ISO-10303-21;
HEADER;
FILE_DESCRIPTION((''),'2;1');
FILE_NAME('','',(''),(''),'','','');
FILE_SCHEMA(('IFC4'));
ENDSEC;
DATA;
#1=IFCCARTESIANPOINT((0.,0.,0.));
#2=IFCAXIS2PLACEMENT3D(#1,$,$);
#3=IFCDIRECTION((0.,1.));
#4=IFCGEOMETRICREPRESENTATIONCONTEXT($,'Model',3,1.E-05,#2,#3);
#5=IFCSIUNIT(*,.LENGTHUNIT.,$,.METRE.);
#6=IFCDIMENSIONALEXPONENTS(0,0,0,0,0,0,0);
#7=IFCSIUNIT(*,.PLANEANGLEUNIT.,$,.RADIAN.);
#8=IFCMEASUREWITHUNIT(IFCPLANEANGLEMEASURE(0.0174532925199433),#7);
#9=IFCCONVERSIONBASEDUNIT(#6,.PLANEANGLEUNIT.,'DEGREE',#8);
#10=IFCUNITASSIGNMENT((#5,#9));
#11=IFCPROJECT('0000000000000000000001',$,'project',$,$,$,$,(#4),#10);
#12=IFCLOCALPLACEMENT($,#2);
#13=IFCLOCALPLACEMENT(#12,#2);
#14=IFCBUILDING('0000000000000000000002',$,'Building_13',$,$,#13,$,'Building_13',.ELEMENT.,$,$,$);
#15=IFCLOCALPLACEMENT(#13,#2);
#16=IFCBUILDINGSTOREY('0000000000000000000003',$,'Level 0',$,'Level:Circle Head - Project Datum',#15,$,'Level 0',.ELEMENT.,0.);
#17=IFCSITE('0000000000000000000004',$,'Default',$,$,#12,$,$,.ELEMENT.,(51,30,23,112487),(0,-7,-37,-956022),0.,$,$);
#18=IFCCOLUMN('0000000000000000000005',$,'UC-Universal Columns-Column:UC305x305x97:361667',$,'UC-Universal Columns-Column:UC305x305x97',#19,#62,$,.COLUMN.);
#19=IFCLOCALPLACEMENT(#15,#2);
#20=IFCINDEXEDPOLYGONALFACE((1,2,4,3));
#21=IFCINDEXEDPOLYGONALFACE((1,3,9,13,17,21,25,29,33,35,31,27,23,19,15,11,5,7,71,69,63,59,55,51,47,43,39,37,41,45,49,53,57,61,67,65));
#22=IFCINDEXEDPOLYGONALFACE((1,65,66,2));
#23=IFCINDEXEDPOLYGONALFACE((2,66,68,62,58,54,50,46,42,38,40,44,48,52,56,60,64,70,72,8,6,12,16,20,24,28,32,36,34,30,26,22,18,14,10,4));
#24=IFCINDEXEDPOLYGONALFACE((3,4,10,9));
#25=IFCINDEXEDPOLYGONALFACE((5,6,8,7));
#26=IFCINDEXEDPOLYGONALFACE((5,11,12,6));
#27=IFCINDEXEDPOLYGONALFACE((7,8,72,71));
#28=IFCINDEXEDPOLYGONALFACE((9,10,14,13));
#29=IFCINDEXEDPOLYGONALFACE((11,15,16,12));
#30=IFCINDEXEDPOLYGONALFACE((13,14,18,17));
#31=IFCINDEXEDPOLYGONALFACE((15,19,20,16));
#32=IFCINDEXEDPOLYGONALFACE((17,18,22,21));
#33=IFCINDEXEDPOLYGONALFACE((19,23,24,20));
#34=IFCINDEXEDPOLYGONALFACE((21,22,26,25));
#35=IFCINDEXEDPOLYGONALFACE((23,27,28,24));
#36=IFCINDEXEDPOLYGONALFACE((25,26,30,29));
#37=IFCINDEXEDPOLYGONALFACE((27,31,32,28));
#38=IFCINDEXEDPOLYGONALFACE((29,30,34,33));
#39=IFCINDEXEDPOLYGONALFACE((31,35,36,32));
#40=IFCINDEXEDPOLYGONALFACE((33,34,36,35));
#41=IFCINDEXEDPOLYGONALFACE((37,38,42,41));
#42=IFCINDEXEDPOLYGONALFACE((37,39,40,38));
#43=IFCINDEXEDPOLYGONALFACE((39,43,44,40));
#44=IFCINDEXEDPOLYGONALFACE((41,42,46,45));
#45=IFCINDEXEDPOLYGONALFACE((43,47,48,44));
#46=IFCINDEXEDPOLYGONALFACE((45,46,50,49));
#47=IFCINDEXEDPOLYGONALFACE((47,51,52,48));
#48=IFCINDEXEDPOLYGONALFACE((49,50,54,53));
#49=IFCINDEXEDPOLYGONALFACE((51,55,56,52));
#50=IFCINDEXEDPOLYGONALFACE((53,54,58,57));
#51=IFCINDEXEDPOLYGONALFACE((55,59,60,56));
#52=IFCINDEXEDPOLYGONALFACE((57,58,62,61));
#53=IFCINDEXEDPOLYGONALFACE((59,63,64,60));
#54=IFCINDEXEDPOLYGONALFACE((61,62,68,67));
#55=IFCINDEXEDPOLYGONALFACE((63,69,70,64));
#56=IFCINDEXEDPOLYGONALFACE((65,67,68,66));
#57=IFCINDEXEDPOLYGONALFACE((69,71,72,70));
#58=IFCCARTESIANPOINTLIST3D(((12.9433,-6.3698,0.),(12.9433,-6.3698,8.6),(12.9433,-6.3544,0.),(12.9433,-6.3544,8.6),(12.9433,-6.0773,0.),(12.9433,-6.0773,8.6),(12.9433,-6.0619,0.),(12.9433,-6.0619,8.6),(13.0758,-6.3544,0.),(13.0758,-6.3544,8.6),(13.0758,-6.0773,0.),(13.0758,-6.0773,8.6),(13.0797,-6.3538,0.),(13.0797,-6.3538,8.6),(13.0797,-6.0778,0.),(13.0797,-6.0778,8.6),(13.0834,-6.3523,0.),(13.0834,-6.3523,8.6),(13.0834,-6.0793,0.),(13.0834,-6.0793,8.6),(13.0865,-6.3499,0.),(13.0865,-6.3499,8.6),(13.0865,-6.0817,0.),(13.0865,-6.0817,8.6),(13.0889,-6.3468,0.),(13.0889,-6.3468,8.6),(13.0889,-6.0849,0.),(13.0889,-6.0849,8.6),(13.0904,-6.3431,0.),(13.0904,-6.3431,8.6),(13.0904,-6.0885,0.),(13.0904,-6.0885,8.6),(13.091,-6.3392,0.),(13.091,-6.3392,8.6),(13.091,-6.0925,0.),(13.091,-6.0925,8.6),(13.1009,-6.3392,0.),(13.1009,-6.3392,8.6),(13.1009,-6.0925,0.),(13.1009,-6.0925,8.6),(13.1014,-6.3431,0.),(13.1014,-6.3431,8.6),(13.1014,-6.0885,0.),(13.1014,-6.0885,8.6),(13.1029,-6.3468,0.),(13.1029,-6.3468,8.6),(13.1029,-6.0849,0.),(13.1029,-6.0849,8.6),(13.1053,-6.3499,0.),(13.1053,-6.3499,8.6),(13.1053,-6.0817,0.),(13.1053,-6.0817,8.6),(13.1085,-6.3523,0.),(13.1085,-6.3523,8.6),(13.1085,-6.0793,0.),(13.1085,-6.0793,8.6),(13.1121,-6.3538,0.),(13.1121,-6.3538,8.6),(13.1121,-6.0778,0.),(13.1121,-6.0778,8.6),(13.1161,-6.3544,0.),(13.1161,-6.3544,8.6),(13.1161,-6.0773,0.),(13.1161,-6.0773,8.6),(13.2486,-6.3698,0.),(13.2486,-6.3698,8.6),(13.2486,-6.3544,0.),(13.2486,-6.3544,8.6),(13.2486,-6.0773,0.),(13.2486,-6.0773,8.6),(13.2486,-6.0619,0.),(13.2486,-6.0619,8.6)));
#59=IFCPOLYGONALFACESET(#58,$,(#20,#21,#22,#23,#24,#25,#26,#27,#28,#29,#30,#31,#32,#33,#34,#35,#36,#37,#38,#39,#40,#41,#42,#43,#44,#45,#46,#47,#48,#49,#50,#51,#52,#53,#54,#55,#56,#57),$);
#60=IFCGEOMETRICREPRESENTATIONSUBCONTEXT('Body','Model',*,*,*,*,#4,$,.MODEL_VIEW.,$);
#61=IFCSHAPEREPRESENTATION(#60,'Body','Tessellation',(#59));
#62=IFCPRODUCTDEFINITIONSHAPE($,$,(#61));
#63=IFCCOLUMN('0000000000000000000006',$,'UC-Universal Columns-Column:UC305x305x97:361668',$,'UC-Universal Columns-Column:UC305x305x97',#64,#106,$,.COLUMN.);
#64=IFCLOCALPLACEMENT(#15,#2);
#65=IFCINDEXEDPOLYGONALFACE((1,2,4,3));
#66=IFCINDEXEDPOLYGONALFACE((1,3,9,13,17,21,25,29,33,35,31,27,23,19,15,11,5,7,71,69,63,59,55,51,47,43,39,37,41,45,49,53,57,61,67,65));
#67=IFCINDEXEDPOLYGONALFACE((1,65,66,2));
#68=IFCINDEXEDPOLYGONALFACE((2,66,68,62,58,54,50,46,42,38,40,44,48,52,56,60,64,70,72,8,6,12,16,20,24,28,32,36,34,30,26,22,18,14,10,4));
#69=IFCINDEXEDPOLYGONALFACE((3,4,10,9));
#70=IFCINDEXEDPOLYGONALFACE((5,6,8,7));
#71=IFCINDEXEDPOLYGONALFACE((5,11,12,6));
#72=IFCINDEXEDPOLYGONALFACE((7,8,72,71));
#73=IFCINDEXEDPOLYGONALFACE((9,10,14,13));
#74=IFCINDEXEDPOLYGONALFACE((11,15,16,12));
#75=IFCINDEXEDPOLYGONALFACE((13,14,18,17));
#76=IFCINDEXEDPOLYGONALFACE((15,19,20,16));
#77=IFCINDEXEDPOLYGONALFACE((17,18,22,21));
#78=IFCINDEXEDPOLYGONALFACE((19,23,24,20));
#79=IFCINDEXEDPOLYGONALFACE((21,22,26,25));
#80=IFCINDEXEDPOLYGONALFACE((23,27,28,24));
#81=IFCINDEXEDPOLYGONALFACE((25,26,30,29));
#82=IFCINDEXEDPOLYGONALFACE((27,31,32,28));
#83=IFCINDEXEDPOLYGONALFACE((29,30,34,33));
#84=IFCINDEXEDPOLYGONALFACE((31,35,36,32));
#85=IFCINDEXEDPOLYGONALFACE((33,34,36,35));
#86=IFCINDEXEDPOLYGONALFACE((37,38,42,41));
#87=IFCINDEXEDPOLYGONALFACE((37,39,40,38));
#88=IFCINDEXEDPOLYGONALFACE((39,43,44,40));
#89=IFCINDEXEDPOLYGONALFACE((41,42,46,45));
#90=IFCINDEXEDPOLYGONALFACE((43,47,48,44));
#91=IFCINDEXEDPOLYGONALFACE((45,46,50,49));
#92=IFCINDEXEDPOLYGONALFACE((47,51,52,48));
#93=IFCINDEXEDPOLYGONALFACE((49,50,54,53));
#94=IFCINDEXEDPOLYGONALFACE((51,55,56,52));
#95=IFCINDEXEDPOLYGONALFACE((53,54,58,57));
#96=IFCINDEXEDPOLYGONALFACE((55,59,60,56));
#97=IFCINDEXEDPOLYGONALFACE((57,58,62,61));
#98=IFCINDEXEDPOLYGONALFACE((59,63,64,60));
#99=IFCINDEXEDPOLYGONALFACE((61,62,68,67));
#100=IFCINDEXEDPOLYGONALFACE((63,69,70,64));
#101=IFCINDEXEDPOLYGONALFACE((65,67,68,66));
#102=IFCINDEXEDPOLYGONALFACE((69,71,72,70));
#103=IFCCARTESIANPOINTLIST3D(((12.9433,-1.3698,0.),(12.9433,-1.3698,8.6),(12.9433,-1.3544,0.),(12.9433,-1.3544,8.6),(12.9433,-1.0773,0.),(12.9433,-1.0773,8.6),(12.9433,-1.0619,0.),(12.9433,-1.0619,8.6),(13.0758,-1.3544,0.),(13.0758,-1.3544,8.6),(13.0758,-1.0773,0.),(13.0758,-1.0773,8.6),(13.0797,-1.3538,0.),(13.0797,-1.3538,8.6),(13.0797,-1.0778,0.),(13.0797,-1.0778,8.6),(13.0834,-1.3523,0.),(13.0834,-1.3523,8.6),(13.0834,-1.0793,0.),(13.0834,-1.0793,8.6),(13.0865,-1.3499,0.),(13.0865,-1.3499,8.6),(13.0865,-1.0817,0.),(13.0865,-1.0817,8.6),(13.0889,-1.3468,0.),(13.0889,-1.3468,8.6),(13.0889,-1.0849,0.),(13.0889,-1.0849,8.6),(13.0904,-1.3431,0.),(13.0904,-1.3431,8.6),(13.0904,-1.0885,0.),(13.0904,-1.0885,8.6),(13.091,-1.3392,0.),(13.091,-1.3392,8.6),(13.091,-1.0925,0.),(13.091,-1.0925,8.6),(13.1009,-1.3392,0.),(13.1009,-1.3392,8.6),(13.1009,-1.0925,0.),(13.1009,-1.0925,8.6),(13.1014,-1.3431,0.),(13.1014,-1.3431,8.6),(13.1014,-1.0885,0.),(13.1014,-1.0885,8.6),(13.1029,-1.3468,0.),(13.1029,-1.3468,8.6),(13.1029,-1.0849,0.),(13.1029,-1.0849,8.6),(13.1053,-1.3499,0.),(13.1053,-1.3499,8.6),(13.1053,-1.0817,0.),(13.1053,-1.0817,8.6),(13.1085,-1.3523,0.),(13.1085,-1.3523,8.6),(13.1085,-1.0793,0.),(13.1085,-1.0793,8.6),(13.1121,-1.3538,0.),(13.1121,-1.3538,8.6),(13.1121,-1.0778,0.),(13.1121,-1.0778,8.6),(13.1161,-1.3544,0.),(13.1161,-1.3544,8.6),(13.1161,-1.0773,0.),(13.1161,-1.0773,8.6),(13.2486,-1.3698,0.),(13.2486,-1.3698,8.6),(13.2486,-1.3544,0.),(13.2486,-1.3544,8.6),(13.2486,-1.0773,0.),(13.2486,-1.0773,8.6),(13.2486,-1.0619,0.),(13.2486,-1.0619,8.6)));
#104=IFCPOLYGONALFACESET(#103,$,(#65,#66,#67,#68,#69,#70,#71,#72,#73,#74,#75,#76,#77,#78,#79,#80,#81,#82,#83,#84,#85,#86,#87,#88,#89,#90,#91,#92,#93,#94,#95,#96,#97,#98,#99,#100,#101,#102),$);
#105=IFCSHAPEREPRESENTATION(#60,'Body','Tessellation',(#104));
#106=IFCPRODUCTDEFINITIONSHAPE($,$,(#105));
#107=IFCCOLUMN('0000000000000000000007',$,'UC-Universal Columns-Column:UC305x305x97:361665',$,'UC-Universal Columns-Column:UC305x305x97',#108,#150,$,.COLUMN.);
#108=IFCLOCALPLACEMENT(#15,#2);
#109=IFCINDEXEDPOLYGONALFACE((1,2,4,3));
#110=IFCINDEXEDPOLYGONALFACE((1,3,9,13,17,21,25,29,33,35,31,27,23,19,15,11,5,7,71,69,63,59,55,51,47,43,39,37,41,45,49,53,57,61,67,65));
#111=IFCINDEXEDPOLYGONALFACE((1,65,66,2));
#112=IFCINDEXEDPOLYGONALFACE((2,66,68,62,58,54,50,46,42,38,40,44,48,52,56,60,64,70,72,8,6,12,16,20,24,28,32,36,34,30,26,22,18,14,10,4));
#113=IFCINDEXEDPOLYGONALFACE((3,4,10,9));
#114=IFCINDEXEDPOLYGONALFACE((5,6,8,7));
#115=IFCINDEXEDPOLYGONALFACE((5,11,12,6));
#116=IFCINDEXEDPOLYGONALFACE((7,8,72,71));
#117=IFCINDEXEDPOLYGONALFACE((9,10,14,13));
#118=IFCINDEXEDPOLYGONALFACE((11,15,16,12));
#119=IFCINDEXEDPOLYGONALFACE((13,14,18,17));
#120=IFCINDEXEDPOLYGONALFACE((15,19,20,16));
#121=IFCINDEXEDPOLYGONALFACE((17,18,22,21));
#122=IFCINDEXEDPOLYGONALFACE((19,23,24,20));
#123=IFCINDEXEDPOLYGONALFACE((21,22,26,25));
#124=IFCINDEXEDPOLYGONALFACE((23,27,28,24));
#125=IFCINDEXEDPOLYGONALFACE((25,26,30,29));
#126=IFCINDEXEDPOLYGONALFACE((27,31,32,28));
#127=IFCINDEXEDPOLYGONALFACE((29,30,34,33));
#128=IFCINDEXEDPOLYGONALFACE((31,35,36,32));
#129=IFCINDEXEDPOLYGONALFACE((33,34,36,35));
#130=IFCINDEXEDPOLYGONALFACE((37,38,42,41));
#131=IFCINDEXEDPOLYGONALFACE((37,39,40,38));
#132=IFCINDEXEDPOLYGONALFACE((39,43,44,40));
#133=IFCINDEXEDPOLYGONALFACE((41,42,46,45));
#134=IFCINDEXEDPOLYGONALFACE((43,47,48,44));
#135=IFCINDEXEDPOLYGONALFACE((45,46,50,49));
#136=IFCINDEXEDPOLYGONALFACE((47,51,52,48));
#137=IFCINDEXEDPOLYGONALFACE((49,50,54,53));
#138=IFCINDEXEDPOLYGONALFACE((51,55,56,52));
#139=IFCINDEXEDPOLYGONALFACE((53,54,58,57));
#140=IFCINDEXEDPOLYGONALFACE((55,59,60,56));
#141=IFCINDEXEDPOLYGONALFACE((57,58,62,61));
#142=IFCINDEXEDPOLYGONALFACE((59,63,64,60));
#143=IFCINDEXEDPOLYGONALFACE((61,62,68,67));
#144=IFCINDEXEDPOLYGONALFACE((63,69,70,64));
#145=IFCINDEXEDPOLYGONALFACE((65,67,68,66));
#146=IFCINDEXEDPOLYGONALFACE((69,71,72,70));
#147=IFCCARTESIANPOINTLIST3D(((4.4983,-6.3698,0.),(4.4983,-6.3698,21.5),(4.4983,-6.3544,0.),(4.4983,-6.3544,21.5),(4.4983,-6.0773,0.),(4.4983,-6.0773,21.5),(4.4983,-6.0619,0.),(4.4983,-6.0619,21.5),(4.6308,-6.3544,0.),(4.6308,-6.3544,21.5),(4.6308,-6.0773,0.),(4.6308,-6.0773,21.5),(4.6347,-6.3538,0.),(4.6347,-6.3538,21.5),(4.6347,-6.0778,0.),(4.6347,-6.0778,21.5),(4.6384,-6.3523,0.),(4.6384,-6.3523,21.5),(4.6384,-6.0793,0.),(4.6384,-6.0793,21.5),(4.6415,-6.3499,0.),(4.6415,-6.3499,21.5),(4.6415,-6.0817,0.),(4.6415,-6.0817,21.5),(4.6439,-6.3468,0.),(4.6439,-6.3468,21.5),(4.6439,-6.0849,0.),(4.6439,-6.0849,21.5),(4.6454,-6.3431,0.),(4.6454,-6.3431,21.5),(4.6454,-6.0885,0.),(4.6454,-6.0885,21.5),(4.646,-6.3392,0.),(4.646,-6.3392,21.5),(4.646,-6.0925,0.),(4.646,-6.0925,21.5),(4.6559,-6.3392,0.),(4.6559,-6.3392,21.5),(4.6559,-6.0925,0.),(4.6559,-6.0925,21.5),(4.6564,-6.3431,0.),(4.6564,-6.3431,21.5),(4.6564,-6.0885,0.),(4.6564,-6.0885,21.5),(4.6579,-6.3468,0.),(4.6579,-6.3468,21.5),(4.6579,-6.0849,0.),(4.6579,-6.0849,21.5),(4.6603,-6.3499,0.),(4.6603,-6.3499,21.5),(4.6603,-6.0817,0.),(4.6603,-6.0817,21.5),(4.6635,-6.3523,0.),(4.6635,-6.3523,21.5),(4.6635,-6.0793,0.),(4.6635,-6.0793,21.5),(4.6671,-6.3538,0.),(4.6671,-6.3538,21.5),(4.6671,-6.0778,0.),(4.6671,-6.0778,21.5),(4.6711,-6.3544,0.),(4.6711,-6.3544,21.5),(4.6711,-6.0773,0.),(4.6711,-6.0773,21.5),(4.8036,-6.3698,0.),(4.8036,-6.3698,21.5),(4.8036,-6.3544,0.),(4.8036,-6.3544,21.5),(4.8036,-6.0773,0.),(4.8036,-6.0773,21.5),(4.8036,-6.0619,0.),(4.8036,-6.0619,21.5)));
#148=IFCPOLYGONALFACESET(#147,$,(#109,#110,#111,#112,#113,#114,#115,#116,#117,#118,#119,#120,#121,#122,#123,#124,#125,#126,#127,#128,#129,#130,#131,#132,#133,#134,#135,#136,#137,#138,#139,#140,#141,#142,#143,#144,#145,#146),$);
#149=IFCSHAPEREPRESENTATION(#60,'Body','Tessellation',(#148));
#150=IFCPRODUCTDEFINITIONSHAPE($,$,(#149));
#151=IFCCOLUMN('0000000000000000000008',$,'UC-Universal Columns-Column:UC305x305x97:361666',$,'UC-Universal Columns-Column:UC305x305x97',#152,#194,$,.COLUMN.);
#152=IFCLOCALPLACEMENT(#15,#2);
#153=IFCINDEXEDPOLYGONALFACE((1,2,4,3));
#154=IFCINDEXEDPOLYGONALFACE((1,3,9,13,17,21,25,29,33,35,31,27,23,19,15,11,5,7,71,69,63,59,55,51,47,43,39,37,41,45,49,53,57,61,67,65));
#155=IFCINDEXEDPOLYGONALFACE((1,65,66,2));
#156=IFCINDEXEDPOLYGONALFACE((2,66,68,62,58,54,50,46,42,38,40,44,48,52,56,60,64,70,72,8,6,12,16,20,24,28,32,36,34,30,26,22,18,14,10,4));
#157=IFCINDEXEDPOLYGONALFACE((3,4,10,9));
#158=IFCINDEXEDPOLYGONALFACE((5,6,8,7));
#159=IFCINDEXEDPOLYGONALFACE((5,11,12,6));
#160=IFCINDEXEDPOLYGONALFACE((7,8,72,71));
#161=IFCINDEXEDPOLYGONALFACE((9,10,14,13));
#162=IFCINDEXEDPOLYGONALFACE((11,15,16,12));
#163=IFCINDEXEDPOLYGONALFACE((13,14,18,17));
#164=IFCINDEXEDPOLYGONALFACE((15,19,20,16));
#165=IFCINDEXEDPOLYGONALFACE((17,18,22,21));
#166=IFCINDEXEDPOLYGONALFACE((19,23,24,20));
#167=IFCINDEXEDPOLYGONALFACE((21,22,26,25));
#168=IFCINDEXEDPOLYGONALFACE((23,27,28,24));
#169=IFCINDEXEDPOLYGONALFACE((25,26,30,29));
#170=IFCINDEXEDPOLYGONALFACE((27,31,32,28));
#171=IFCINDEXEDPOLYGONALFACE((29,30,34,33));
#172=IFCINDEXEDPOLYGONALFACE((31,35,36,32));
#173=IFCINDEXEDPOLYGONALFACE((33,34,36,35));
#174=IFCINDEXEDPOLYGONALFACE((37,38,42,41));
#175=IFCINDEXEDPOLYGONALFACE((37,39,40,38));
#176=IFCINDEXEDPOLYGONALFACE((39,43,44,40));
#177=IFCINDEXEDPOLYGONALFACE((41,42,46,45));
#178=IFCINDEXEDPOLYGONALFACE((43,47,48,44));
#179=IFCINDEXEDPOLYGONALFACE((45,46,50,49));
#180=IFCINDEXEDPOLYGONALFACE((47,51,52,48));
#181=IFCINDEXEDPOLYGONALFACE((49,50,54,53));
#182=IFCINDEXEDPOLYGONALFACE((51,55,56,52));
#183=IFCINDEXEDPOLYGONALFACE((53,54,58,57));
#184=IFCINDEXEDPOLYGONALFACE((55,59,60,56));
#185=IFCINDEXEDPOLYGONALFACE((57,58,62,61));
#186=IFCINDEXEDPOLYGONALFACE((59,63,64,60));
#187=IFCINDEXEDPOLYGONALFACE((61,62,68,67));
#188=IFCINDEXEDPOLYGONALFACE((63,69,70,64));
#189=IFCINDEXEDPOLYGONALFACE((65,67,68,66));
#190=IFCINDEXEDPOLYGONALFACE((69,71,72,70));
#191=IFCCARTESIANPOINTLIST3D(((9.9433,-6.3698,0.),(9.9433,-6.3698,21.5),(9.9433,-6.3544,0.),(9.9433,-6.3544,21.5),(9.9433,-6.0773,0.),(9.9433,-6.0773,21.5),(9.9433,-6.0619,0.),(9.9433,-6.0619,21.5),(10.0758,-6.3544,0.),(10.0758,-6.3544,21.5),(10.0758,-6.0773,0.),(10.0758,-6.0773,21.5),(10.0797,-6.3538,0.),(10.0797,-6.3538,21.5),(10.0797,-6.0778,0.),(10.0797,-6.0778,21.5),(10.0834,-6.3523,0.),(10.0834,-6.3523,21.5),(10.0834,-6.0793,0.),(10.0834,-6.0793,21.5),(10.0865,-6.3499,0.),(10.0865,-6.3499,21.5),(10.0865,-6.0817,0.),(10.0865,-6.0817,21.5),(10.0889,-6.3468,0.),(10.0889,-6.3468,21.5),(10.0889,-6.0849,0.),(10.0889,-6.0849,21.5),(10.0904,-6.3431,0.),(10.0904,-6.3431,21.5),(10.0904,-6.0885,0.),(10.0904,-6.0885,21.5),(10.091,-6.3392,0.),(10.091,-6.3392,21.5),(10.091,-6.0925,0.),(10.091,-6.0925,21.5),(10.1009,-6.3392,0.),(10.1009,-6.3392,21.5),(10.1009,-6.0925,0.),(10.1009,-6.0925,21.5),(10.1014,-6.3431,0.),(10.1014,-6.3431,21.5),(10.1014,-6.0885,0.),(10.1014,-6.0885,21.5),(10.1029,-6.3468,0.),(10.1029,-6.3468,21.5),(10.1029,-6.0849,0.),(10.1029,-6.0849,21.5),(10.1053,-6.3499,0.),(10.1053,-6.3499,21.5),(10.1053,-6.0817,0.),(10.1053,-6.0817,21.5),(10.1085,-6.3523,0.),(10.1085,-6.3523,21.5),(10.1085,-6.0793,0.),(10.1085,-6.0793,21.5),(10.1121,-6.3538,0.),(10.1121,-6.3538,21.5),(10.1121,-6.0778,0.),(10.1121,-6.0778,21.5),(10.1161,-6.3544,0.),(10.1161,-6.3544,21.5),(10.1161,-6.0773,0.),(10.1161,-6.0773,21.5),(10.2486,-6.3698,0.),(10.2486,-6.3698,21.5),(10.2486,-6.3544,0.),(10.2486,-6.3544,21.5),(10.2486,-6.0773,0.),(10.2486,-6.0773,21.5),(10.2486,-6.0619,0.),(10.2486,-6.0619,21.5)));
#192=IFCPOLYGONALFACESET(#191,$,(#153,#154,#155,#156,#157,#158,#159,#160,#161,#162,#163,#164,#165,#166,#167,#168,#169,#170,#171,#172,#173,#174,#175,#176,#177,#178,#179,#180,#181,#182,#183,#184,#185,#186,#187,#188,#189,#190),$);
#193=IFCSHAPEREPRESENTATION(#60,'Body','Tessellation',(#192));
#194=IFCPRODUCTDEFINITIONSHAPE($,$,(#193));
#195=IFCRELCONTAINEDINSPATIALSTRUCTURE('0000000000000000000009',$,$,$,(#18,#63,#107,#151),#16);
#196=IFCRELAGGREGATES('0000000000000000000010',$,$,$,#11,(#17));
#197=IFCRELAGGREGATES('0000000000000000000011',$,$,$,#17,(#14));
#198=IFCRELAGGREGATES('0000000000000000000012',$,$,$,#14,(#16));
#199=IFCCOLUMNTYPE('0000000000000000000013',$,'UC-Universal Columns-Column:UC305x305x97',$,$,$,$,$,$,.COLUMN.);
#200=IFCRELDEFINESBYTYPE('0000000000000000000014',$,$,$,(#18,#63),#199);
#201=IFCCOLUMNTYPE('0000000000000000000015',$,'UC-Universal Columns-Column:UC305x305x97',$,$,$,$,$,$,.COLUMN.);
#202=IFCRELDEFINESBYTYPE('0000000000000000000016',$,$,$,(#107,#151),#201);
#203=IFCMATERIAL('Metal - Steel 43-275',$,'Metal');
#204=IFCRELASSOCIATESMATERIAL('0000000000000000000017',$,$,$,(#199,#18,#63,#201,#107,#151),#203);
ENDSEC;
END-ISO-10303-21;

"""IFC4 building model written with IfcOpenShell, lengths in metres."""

from ifc_helpers import new_model, entity, si_unit, converted_unit, direction, frame, origin, place, context, subcontext, project, spatial, line, arc, indexed_curve, outline, extrude, source, transform, mapped, material, type_object, type_shapes, element, save


model = new_model("IFC4")

# Units and contexts
model_context = context("Model", 3, precision=1e-05, world=origin(), true_north=direction((0.0, 1.0)))
body_context = subcontext(model_context, "Body", "Model", "MODEL_VIEW")
ifc_project = project(units=[si_unit("LENGTHUNIT", "METRE"), converted_unit("PLANEANGLEUNIT", "DEGREE", entity("IfcPlaneAngleMeasure", 0.0174532925199433), si_unit("PLANEANGLEUNIT", "RADIAN"), dimensions=[0, 0, 0, 0, 0, 0, 0])], contexts=[model_context])

# Site, building, storey
site_placement = place(None, origin())
site = spatial("IfcSite", under=ifc_project, at=site_placement, Name="Default", CompositionType="ELEMENT", RefLatitude=(51, 30, 23, 112487), RefLongitude=(0, -7, -37, -956022), RefElevation=0.0)
building_placement = place(site_placement, origin())
building = spatial("IfcBuilding", under=site, at=building_placement, Name="Building_13", LongName="Building_13", CompositionType="ELEMENT")
storey_placement = place(building_placement, origin())
storey = spatial("IfcBuildingStorey", under=building, at=storey_placement, Name="Level 0", ObjectType="Level:Circle Head - Project Datum", LongName="Level 0", CompositionType="ELEMENT", Elevation=0.0)

# Columns
ifc_material_1 = material(Name="Metal - Steel 43-275", Category="Metal")
column_type_1 = type_object("IfcColumnType", Name="UC-Universal Columns-Column:UC305x305x97", PredefinedType="COLUMN", material=ifc_material_1)
shared_shape_1 = source(origin(), body_context, "Body", "SweptSolid", [
    extrude(outline(indexed_curve([(-0.154, -0.1527), (-0.1386, -0.1527), (-0.1386, -0.0201), (-0.1341, -0.0094), (-0.1234, -0.005), (0.1234, -0.005), (0.1341, -0.0094), (0.1386, -0.0202), (0.1386, -0.1527), (0.154, -0.1527), (0.154, 0.1527), (0.1386, 0.1527), (0.1386, 0.0201), (0.1341, 0.0094), (0.1234, 0.0049), (-0.1234, 0.0049), (-0.1341, 0.0094), (-0.1386, 0.0202), (-0.1386, 0.1527), (-0.154, 0.1527)], segments=[line(1, 2, 3), arc(3, 4, 5), line(5, 6), arc(6, 7, 8), line(8, 9, 10, 11, 12, 13), arc(13, 14, 15), line(15, 16), arc(16, 17, 18), line(18, 19, 20, 1)], self_intersect=False)), frame((0.0, 0.0, 0.0), z_axis=(0.0, 0.0, 1.0), x_axis=(0.0, 1.0, 0.0)), (0.0, 0.0, 1.0), 8.6),
])
type_shapes(column_type_1, [shared_shape_1])
for number, where, name in (
    (1, (13.0959, -6.2158, 0.0), "UC-Universal Columns-Column:UC305x305x97:361667"),
    (2, (13.0959, -1.2158, 0.0), "UC-Universal Columns-Column:UC305x305x97:361668"),
):
    element("IfcColumn", number, at=place(storey_placement, frame(where)), inside=storey, type_object=column_type_1, material=ifc_material_1, Name=name, ObjectType="UC-Universal Columns-Column:UC305x305x97", PredefinedType="COLUMN", context=body_context, shape_type="MappedRepresentation", body=[
        mapped(shared_shape_1, transform((0.0, 0.0, 0.0), scale=1.0)),
    ])
column_type_2 = type_object("IfcColumnType", Name="UC-Universal Columns-Column:UC305x305x97", PredefinedType="COLUMN", material=ifc_material_1)
shared_shape_2 = source(origin(), body_context, "Body", "SweptSolid", [
    extrude(outline(indexed_curve([(-0.154, -0.1527), (-0.1386, -0.1527), (-0.1386, -0.0201), (-0.1341, -0.0094), (-0.1234, -0.005), (0.1234, -0.005), (0.1341, -0.0094), (0.1386, -0.0202), (0.1386, -0.1527), (0.154, -0.1527), (0.154, 0.1527), (0.1386, 0.1527), (0.1386, 0.0201), (0.1341, 0.0094), (0.1234, 0.0049), (-0.1234, 0.0049), (-0.1341, 0.0094), (-0.1386, 0.0202), (-0.1386, 0.1527), (-0.154, 0.1527)], segments=[line(1, 2, 3), arc(3, 4, 5), line(5, 6), arc(6, 7, 8), line(8, 9, 10, 11, 12, 13), arc(13, 14, 15), line(15, 16), arc(16, 17, 18), line(18, 19, 20, 1)], self_intersect=False)), frame((0.0, 0.0, 0.0), z_axis=(0.0, 0.0, 1.0), x_axis=(0.0, 1.0, 0.0)), (0.0, 0.0, 1.0), 21.5),
])
type_shapes(column_type_2, [shared_shape_2])
for number, where, name in (
    (3, (4.6509, -6.2158, 0.0), "UC-Universal Columns-Column:UC305x305x97:361665"),
    (4, (10.0959, -6.2158, 0.0), "UC-Universal Columns-Column:UC305x305x97:361666"),
):
    element("IfcColumn", number, at=place(storey_placement, frame(where)), inside=storey, type_object=column_type_2, material=ifc_material_1, Name=name, ObjectType="UC-Universal Columns-Column:UC305x305x97", PredefinedType="COLUMN", context=body_context, shape_type="MappedRepresentation", body=[
        mapped(shared_shape_2, transform((0.0, 0.0, 0.0), scale=1.0)),
    ])

save(model, "model.ifc")
